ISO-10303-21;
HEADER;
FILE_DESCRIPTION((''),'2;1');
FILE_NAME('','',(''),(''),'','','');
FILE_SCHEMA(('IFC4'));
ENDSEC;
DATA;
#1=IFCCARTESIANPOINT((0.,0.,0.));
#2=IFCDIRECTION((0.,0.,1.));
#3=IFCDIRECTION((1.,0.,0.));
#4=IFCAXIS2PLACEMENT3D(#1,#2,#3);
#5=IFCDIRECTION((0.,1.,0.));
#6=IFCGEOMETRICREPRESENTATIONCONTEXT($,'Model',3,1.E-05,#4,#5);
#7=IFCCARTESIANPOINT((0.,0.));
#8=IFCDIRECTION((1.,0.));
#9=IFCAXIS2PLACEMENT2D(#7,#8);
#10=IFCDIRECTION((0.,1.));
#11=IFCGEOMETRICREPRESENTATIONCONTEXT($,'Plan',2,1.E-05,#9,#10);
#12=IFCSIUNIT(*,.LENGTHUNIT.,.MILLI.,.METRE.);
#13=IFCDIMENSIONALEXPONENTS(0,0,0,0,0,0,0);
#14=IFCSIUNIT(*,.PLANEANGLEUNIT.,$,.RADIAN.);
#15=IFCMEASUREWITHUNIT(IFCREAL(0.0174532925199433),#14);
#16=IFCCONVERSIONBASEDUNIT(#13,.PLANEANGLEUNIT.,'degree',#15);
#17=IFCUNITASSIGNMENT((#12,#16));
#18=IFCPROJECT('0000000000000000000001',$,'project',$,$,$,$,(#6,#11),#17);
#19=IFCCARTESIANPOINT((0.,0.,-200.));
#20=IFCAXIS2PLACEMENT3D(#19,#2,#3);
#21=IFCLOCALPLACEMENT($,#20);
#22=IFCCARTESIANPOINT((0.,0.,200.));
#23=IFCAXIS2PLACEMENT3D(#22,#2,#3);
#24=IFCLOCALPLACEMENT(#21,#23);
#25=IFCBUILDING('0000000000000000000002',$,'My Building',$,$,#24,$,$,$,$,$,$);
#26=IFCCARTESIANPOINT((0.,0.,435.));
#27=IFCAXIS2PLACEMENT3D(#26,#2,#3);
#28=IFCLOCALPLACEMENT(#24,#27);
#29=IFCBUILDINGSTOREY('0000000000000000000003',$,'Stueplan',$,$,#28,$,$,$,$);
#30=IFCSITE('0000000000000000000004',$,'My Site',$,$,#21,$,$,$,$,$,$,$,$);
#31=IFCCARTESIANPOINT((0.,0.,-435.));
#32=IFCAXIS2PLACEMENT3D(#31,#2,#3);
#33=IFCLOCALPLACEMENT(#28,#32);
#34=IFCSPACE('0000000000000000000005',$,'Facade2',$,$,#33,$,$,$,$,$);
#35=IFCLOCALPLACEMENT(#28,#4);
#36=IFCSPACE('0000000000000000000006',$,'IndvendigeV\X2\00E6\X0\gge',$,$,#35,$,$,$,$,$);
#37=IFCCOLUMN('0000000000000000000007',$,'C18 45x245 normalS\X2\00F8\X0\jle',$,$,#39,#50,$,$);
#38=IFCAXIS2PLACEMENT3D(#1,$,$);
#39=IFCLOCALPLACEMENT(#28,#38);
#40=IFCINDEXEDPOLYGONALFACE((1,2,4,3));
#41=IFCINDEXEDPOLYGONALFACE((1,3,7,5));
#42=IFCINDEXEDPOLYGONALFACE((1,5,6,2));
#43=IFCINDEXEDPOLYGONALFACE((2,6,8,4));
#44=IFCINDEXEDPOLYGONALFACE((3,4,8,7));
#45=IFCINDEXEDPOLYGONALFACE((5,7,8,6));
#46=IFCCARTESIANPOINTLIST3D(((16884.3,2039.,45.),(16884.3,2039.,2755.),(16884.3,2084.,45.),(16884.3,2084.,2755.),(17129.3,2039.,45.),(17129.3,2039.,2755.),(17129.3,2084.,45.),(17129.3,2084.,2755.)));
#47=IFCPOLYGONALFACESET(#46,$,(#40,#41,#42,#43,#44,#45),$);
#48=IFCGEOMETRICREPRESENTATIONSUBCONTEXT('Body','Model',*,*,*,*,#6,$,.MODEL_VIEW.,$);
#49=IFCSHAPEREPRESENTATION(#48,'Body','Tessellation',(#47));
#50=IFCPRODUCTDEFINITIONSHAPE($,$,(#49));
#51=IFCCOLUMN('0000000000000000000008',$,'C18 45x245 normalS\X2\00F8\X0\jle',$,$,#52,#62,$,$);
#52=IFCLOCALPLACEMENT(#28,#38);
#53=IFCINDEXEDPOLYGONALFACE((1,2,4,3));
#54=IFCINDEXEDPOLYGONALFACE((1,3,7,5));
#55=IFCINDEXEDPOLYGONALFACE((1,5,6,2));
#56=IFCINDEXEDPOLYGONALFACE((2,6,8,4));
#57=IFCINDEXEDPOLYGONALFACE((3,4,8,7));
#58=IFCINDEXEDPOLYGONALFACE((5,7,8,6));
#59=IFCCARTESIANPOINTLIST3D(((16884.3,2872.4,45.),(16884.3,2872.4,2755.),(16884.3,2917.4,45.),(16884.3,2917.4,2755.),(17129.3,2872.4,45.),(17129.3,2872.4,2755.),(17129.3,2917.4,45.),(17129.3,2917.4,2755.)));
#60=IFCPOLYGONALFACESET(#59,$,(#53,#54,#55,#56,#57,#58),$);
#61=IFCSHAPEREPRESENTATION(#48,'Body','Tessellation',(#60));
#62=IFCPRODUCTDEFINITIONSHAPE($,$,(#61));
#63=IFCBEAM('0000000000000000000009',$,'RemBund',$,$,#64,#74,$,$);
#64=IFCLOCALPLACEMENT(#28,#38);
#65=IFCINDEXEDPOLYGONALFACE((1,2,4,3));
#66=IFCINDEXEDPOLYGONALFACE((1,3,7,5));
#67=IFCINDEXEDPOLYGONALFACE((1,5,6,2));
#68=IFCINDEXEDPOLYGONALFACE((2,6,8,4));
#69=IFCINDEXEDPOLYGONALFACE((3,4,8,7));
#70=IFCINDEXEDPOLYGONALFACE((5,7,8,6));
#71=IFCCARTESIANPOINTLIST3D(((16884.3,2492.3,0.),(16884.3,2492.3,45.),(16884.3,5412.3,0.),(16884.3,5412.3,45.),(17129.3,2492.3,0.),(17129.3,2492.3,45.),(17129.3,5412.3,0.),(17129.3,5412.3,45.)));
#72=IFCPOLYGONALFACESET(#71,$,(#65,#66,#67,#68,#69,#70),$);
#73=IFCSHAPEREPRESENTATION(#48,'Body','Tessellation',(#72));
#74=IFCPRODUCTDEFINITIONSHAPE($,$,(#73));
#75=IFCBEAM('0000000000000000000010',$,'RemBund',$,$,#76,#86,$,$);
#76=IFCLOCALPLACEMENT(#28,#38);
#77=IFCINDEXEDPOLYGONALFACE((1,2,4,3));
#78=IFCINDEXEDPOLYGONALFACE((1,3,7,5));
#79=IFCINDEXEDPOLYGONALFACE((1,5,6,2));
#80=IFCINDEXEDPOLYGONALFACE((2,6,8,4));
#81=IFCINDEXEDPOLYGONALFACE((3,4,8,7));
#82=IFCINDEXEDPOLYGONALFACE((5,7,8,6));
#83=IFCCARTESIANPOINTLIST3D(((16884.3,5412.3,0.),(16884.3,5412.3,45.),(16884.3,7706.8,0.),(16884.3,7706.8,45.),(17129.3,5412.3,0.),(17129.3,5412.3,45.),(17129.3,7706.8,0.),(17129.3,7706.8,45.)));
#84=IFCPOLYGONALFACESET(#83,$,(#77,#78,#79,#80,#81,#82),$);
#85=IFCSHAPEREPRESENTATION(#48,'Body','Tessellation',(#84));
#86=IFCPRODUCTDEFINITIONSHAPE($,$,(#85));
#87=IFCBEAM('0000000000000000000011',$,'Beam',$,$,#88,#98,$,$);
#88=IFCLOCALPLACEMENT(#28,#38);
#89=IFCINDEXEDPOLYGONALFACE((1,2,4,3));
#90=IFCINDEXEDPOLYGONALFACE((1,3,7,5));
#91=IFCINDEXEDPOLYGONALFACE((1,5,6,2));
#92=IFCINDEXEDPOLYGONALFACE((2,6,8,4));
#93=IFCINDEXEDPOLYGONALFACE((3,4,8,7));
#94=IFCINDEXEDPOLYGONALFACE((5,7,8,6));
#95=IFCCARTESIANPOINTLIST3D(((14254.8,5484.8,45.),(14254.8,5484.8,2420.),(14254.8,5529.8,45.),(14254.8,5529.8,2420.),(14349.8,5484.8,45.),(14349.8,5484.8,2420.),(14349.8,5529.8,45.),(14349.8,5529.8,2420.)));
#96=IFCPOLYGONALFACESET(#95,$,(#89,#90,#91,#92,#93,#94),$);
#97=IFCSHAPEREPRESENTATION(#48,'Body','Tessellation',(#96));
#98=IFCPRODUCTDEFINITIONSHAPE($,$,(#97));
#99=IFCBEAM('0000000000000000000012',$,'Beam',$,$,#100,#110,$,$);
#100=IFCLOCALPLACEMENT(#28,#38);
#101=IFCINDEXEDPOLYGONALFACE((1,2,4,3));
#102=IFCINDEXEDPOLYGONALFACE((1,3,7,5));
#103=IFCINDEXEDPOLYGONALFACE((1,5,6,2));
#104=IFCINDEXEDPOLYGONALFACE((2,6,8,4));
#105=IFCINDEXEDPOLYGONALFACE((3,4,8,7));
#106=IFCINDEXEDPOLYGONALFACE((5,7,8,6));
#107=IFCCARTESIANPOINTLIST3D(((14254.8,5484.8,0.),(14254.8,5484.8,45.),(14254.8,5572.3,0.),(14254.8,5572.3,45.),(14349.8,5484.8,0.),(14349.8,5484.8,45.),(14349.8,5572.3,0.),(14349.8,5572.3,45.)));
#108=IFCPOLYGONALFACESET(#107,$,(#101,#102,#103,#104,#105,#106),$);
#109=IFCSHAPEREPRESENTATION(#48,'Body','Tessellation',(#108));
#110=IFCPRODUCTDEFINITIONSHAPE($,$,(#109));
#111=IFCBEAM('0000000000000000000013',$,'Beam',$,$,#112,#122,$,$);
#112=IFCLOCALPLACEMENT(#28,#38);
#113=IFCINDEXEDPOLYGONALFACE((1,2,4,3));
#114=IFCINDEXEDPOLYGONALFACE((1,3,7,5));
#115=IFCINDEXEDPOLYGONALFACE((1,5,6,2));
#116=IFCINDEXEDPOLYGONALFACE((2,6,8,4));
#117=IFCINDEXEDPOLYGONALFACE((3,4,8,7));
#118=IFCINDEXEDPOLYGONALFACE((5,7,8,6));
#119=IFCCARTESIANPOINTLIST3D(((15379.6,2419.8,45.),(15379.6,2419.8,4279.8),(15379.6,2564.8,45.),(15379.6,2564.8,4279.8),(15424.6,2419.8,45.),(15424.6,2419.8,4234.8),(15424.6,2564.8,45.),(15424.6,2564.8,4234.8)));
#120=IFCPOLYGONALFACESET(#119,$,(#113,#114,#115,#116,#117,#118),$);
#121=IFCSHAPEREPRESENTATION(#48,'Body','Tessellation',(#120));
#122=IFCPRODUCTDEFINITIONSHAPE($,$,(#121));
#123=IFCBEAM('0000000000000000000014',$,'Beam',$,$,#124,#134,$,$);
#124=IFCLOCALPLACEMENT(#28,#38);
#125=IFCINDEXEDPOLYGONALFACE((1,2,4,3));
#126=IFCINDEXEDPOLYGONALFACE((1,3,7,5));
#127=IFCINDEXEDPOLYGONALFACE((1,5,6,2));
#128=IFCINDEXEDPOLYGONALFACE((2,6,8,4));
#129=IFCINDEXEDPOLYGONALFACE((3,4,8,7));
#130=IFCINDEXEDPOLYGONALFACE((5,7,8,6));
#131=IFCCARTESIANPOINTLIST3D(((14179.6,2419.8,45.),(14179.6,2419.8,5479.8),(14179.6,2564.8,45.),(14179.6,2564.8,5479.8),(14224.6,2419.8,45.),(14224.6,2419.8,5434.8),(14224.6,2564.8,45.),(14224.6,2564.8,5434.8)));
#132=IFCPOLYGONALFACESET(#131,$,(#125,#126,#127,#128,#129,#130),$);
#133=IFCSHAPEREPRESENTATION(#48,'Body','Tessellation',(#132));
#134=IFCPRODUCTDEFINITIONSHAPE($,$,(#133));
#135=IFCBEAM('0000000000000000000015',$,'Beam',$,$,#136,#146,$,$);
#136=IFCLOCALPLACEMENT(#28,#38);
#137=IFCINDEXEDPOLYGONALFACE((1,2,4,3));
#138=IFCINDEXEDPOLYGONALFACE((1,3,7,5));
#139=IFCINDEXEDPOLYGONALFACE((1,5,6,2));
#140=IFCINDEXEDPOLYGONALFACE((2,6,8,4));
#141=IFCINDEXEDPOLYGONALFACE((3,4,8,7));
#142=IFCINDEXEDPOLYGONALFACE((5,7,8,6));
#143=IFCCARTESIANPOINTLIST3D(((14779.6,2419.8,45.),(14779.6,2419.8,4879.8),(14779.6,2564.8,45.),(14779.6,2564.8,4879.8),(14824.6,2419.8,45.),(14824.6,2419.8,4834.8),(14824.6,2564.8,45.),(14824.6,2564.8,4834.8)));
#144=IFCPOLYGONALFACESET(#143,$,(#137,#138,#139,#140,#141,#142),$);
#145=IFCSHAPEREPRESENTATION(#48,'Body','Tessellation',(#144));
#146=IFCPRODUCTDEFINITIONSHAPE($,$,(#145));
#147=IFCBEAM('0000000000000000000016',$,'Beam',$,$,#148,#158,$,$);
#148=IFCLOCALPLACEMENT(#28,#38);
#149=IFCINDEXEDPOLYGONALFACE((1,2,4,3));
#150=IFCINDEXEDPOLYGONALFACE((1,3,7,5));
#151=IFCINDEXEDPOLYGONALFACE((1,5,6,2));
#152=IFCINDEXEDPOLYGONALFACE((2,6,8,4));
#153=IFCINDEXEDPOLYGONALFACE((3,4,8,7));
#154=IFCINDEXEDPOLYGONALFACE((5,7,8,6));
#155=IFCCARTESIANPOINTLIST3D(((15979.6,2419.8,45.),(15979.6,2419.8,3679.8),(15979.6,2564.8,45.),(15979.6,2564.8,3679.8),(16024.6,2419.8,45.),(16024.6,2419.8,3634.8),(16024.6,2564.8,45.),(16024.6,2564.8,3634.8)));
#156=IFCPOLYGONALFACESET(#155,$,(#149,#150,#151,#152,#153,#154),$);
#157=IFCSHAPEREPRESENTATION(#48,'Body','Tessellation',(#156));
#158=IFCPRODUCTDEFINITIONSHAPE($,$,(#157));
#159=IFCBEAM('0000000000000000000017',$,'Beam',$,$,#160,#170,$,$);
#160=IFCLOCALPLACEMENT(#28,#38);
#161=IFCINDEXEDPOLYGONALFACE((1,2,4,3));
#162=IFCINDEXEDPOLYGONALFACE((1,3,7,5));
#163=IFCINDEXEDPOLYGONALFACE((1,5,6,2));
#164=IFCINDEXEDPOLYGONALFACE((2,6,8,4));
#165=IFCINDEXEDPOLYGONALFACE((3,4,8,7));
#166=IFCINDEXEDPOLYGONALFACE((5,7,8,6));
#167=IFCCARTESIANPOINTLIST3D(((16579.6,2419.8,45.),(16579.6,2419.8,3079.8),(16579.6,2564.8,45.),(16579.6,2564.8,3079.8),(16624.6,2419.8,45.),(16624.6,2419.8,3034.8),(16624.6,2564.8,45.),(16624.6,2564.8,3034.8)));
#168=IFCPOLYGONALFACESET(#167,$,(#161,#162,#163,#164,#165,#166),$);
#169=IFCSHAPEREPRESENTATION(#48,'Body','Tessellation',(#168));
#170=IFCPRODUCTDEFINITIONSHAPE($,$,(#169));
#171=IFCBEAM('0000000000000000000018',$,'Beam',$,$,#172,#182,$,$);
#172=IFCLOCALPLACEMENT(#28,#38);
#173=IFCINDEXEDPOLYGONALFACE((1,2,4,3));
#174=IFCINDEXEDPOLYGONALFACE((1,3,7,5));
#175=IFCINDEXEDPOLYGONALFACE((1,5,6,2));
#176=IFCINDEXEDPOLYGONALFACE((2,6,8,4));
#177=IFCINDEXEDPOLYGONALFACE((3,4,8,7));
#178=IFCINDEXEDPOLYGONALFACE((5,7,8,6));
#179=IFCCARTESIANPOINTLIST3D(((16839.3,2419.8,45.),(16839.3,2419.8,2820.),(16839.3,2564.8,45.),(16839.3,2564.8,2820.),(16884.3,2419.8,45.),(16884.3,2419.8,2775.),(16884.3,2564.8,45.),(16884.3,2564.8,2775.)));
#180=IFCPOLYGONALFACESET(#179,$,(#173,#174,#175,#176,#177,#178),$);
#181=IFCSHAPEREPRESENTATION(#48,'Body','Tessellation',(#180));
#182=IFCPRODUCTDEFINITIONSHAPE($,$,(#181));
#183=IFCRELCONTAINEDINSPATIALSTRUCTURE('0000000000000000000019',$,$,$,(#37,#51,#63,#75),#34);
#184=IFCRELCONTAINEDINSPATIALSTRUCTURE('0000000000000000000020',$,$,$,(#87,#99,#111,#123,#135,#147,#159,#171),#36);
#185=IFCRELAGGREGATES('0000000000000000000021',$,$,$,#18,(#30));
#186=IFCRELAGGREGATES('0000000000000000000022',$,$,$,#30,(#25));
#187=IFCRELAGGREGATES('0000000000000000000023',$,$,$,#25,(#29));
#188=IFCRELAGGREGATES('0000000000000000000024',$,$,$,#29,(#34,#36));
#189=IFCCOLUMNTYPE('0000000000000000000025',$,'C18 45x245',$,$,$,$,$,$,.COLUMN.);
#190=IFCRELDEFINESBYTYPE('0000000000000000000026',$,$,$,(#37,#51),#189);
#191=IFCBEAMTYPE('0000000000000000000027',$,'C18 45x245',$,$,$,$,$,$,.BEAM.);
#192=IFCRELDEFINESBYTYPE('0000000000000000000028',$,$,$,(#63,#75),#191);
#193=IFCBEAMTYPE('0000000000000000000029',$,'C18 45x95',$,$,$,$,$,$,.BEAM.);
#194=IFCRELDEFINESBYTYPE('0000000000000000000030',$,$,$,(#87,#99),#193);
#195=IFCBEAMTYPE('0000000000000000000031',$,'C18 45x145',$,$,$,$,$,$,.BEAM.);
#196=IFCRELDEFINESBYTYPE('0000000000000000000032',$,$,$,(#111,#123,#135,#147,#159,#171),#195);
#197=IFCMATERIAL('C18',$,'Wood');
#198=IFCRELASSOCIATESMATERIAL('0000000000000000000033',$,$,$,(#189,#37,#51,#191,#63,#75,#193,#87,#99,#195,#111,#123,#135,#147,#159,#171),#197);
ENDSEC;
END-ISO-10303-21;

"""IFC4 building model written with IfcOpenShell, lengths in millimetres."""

from ifc_helpers import new_model, entity, si_unit, converted_unit, direction, frame, origin_with_axes, origin_2d_with_axis, place, context, subcontext, project, spatial, rectangle, extrude, clip, halfspace, material, material_profile, profile_set, profile_usage, type_object, element, save


model = new_model("IFC4")

# Units and contexts
model_context = context("Model", 3, precision=1e-05, world=origin_with_axes(), true_north=direction((0.0, 1.0, 0.0)))
plan_context = context("Plan", 2, precision=1e-05, world=origin_2d_with_axis(), true_north=direction((0.0, 1.0)))
body_context_1 = subcontext(model_context, "Body", "Model", "MODEL_VIEW")
ifc_project = project(units=[si_unit("LENGTHUNIT", "METRE", prefix="MILLI"), converted_unit("PLANEANGLEUNIT", "degree", entity("IfcReal", 0.0174532925199433), si_unit("PLANEANGLEUNIT", "RADIAN"), dimensions=[0, 0, 0, 0, 0, 0, 0])], contexts=[model_context, plan_context])

# Site, building, storey, space
site_placement = place(None, frame((0.0, 0.0, -200.0), z_axis=(0.0, 0.0, 1.0), x_axis=(1.0, 0.0, 0.0)))
site = spatial("IfcSite", under=ifc_project, at=site_placement, Name="My Site")
building_placement = place(site_placement, frame((0.0, 0.0, 200.0), z_axis=(0.0, 0.0, 1.0), x_axis=(1.0, 0.0, 0.0)))
building = spatial("IfcBuilding", under=site, at=building_placement, Name="My Building")
storey_placement = place(building_placement, frame((0.0, 0.0, 435.0), z_axis=(0.0, 0.0, 1.0), x_axis=(1.0, 0.0, 0.0)))
storey = spatial("IfcBuildingStorey", under=building, at=storey_placement, Name="Stueplan")
space_1_placement = place(storey_placement, frame((0.0, 0.0, -435.0), z_axis=(0.0, 0.0, 1.0), x_axis=(1.0, 0.0, 0.0)))
space_1 = spatial("IfcSpace", under=storey, at=space_1_placement, Name="Facade2")

# Columns
ifc_material = material(Name="C18", Category="Wood")
ifc_material_profile_1 = material_profile(ifc_material, rectangle(XDim=45.0, YDim=245.0))
ifc_profile_set_1 = profile_set([ifc_material_profile_1], Name="woodStructural")
column_type = type_object("IfcColumnType", Name="C18 45x245", PredefinedType="COLUMN", material=ifc_profile_set_1)
ifc_profile_usage_1 = profile_usage(ifc_profile_set_1, cardinal=9)
column_1_placement = place(space_1_placement, frame((17129.3, 2084.0, 480.0), z_axis=(0.0, 0.0, 1.0), x_axis=(0.0, -1.0, 0.0)))
element("IfcColumn", 1, at=column_1_placement, inside=space_1, type_object=column_type, material=ifc_profile_usage_1, Name="C18 45x245 normalSøjle", context=body_context_1, shape_type="SweptSolid", body=[
    extrude(rectangle(XDim=45.0, YDim=245.0), frame((22.5, -122.5, 0.0), z_axis=(0.0, 0.0, 1.0), x_axis=(1.0, 0.0, 0.0)), (0.0, 0.0, 1.0), 2710.0),
])
ifc_profile_usage_2 = profile_usage(ifc_profile_set_1, cardinal=9)
column_2_placement = place(space_1_placement, frame((17129.3, 2917.4, 480.0), z_axis=(0.0, 0.0, 1.0), x_axis=(0.0, -1.0, 0.0)))
element("IfcColumn", 2, at=column_2_placement, inside=space_1, type_object=column_type, material=ifc_profile_usage_2, Name="C18 45x245 normalSøjle", context=body_context_1, shape_type="SweptSolid", body=[
    extrude(rectangle(XDim=45.0, YDim=245.0), frame((22.5, -122.5, 0.0), z_axis=(0.0, 0.0, 1.0), x_axis=(1.0, 0.0, 0.0)), (0.0, 0.0, 1.0), 2710.0),
])

# Beams
ifc_material_profile_2 = material_profile(ifc_material, rectangle(XDim=45.0, YDim=245.0), Name="concrete")
ifc_profile_set_2 = profile_set([ifc_material_profile_2], Name="woodStructural")
ifc_profile_usage_3 = profile_usage(ifc_profile_set_2)
beam_type_1 = type_object("IfcBeamType", Name="C18 45x245", PredefinedType="BEAM", material=ifc_profile_set_2)
beam_1_placement = place(space_1_placement, frame((17006.8, 2492.3, 457.5), z_axis=(0.0, 1.0, 0.0), x_axis=(0.0, 0.0, 1.0)))
element("IfcBeam", 3, at=beam_1_placement, inside=space_1, type_object=beam_type_1, material=ifc_profile_usage_3, Name="RemBund", context=body_context_1, shape_type="SweptSolid", body=[
    extrude(rectangle(XDim=45.0, YDim=245.0), origin_with_axes(), (0.0, 0.0, 1.0), 2920.0),
])
ifc_profile_usage_4 = profile_usage(ifc_profile_set_2)
beam_2_placement = place(space_1_placement, frame((17006.8, 5412.3, 457.5), z_axis=(0.0, 1.0, 0.0), x_axis=(0.0, 0.0, 1.0)))
element("IfcBeam", 4, at=beam_2_placement, inside=space_1, type_object=beam_type_1, material=ifc_profile_usage_4, Name="RemBund", context=body_context_1, shape_type="SweptSolid", body=[
    extrude(rectangle(XDim=45.0, YDim=245.0), origin_with_axes(), (0.0, 0.0, 1.0), 2294.5),
])

# Shared definitions
space_2_placement = place(storey_placement, frame((0.0, 0.0, 0.0), z_axis=(0.0, 0.0, 1.0), x_axis=(1.0, 0.0, 0.0)))
space_2 = spatial("IfcSpace", under=storey, at=space_2_placement, Name="IndvendigeVægge")

# Beams
ifc_material_profile_3 = material_profile(ifc_material, rectangle(XDim=45.0, YDim=95.0))
ifc_profile_set_3 = profile_set([ifc_material_profile_3], Name="woodStructural")
ifc_profile_usage_5 = profile_usage(ifc_profile_set_3)
beam_type_2 = type_object("IfcBeamType", Name="C18 45x95", PredefinedType="BEAM", material=ifc_profile_set_3)
beam_3_placement = place(space_2_placement, frame((14302.3, 5507.3, 45.0), z_axis=(0.0, 0.0, 1.0), x_axis=(0.0, -1.0, 0.0)))
element("IfcBeam", 5, at=beam_3_placement, inside=space_2, type_object=beam_type_2, material=ifc_profile_usage_5, Name="Beam", context=body_context_1, shape_type="SweptSolid", body=[
    extrude(rectangle(XDim=45.0, YDim=95.0), origin_with_axes(), (0.0, 0.0, 1.0), 2375.0),
])
ifc_profile_usage_6 = profile_usage(ifc_profile_set_3, cardinal=5)
beam_4_placement = place(space_2_placement, frame((14302.3, 5572.3, 22.5), z_axis=(0.0, -1.0, 0.0), x_axis=(0.0, 0.0, 1.0)))
element("IfcBeam", 6, at=beam_4_placement, inside=space_2, type_object=beam_type_2, material=ifc_profile_usage_6, Name="Beam", context=body_context_1, shape_type="SweptSolid", body=[
    extrude(rectangle(XDim=45.0, YDim=95.0), origin_with_axes(), (0.0, 0.0, 1.0), 87.5),
])
ifc_material_profile_4 = material_profile(ifc_material, rectangle(XDim=45.0, YDim=145.0))
ifc_profile_set_4 = profile_set([ifc_material_profile_4], Name="woodStructural")
ifc_profile_usage_7 = profile_usage(ifc_profile_set_4)
beam_type_3 = type_object("IfcBeamType", Name="C18 45x145", PredefinedType="BEAM", material=ifc_profile_set_4)
beam_5_placement = place(space_2_placement, frame((15402.1, 2492.3, 45.0), z_axis=(0.0, 0.0, 1.0), x_axis=(-1.0, 0.0, 0.0)))
element("IfcBeam", 7, at=beam_5_placement, inside=space_2, type_object=beam_type_3, material=ifc_profile_usage_7, Name="Beam", context=body_context_1, shape_type="Clipping", body=[
    clip(extrude(rectangle(XDim=45.0, YDim=145.0), origin_with_axes(), (0.0, 0.0, 1.0), 4357.3), halfspace(frame((-1568.8, 0.0, 2643.4), z_axis=(-0.707107, 0.0, 0.707106), x_axis=(0.0, 1.0, 0.0)), False)),
])
ifc_profile_usage_8 = profile_usage(ifc_profile_set_4)
beam_6_placement = place(space_2_placement, frame((14202.1, 2492.3, 45.0), z_axis=(0.0, 0.0, 1.0), x_axis=(-1.0, 0.0, 0.0)))
element("IfcBeam", 8, at=beam_6_placement, inside=space_2, type_object=beam_type_3, material=ifc_profile_usage_8, Name="Beam", context=body_context_1, shape_type="Clipping", body=[
    clip(extrude(rectangle(XDim=45.0, YDim=145.0), origin_with_axes(), (0.0, 0.0, 1.0), 5557.3), halfspace(frame((-2768.8, 0.0, 2643.4), z_axis=(-0.707107, 0.0, 0.707106), x_axis=(0.0, 1.0, 0.0)), False)),
])
ifc_profile_usage_9 = profile_usage(ifc_profile_set_4)
beam_7_placement = place(space_2_placement, frame((14802.1, 2492.3, 45.0), z_axis=(0.0, 0.0, 1.0), x_axis=(-1.0, 0.0, 0.0)))
element("IfcBeam", 9, at=beam_7_placement, inside=space_2, type_object=beam_type_3, material=ifc_profile_usage_9, Name="Beam", context=body_context_1, shape_type="Clipping", body=[
    clip(extrude(rectangle(XDim=45.0, YDim=145.0), origin_with_axes(), (0.0, 0.0, 1.0), 4957.3), halfspace(frame((-2168.8, 0.0, 2643.4), z_axis=(-0.707107, 0.0, 0.707106), x_axis=(0.0, 1.0, 0.0)), False)),
])
ifc_profile_usage_10 = profile_usage(ifc_profile_set_4)
beam_8_placement = place(space_2_placement, frame((16002.1, 2492.3, 45.0), z_axis=(0.0, 0.0, 1.0), x_axis=(-1.0, 0.0, 0.0)))
element("IfcBeam", 10, at=beam_8_placement, inside=space_2, type_object=beam_type_3, material=ifc_profile_usage_10, Name="Beam", context=body_context_1, shape_type="Clipping", body=[
    clip(extrude(rectangle(XDim=45.0, YDim=145.0), origin_with_axes(), (0.0, 0.0, 1.0), 3757.2), halfspace(frame((-968.8, 0.0, 2643.4), z_axis=(-0.707107, 0.0, 0.707106), x_axis=(0.0, 1.0, 0.0)), False)),
])
ifc_profile_usage_11 = profile_usage(ifc_profile_set_4)
beam_9_placement = place(space_2_placement, frame((16602.1, 2492.3, 45.0), z_axis=(0.0, 0.0, 1.0), x_axis=(-1.0, 0.0, 0.0)))
element("IfcBeam", 11, at=beam_9_placement, inside=space_2, type_object=beam_type_3, material=ifc_profile_usage_11, Name="Beam", context=body_context_1, shape_type="Clipping", body=[
    clip(extrude(rectangle(XDim=45.0, YDim=145.0), origin_with_axes(), (0.0, 0.0, 1.0), 3157.3), halfspace(frame((-368.8, 0.0, 2643.4), z_axis=(-0.707107, 0.0, 0.707106), x_axis=(0.0, 1.0, 0.0)), False)),
])
ifc_profile_usage_12 = profile_usage(ifc_profile_set_4)
beam_10_placement = place(space_2_placement, frame((16861.8, 2492.3, 45.0), z_axis=(0.0, 0.0, 1.0), x_axis=(-1.0, 0.0, 0.0)))
element("IfcBeam", 12, at=beam_10_placement, inside=space_2, type_object=beam_type_3, material=ifc_profile_usage_12, Name="Beam", context=body_context_1, shape_type="Clipping", body=[
    clip(extrude(rectangle(XDim=45.0, YDim=145.0), origin_with_axes(), (0.0, 0.0, 1.0), 2897.5), halfspace(frame((-109.1, 0.0, 2643.4), z_axis=(-0.707107, 0.0, 0.707106), x_axis=(0.0, 1.0, 0.0)), False)),
])

save(model, "model.ifc")
